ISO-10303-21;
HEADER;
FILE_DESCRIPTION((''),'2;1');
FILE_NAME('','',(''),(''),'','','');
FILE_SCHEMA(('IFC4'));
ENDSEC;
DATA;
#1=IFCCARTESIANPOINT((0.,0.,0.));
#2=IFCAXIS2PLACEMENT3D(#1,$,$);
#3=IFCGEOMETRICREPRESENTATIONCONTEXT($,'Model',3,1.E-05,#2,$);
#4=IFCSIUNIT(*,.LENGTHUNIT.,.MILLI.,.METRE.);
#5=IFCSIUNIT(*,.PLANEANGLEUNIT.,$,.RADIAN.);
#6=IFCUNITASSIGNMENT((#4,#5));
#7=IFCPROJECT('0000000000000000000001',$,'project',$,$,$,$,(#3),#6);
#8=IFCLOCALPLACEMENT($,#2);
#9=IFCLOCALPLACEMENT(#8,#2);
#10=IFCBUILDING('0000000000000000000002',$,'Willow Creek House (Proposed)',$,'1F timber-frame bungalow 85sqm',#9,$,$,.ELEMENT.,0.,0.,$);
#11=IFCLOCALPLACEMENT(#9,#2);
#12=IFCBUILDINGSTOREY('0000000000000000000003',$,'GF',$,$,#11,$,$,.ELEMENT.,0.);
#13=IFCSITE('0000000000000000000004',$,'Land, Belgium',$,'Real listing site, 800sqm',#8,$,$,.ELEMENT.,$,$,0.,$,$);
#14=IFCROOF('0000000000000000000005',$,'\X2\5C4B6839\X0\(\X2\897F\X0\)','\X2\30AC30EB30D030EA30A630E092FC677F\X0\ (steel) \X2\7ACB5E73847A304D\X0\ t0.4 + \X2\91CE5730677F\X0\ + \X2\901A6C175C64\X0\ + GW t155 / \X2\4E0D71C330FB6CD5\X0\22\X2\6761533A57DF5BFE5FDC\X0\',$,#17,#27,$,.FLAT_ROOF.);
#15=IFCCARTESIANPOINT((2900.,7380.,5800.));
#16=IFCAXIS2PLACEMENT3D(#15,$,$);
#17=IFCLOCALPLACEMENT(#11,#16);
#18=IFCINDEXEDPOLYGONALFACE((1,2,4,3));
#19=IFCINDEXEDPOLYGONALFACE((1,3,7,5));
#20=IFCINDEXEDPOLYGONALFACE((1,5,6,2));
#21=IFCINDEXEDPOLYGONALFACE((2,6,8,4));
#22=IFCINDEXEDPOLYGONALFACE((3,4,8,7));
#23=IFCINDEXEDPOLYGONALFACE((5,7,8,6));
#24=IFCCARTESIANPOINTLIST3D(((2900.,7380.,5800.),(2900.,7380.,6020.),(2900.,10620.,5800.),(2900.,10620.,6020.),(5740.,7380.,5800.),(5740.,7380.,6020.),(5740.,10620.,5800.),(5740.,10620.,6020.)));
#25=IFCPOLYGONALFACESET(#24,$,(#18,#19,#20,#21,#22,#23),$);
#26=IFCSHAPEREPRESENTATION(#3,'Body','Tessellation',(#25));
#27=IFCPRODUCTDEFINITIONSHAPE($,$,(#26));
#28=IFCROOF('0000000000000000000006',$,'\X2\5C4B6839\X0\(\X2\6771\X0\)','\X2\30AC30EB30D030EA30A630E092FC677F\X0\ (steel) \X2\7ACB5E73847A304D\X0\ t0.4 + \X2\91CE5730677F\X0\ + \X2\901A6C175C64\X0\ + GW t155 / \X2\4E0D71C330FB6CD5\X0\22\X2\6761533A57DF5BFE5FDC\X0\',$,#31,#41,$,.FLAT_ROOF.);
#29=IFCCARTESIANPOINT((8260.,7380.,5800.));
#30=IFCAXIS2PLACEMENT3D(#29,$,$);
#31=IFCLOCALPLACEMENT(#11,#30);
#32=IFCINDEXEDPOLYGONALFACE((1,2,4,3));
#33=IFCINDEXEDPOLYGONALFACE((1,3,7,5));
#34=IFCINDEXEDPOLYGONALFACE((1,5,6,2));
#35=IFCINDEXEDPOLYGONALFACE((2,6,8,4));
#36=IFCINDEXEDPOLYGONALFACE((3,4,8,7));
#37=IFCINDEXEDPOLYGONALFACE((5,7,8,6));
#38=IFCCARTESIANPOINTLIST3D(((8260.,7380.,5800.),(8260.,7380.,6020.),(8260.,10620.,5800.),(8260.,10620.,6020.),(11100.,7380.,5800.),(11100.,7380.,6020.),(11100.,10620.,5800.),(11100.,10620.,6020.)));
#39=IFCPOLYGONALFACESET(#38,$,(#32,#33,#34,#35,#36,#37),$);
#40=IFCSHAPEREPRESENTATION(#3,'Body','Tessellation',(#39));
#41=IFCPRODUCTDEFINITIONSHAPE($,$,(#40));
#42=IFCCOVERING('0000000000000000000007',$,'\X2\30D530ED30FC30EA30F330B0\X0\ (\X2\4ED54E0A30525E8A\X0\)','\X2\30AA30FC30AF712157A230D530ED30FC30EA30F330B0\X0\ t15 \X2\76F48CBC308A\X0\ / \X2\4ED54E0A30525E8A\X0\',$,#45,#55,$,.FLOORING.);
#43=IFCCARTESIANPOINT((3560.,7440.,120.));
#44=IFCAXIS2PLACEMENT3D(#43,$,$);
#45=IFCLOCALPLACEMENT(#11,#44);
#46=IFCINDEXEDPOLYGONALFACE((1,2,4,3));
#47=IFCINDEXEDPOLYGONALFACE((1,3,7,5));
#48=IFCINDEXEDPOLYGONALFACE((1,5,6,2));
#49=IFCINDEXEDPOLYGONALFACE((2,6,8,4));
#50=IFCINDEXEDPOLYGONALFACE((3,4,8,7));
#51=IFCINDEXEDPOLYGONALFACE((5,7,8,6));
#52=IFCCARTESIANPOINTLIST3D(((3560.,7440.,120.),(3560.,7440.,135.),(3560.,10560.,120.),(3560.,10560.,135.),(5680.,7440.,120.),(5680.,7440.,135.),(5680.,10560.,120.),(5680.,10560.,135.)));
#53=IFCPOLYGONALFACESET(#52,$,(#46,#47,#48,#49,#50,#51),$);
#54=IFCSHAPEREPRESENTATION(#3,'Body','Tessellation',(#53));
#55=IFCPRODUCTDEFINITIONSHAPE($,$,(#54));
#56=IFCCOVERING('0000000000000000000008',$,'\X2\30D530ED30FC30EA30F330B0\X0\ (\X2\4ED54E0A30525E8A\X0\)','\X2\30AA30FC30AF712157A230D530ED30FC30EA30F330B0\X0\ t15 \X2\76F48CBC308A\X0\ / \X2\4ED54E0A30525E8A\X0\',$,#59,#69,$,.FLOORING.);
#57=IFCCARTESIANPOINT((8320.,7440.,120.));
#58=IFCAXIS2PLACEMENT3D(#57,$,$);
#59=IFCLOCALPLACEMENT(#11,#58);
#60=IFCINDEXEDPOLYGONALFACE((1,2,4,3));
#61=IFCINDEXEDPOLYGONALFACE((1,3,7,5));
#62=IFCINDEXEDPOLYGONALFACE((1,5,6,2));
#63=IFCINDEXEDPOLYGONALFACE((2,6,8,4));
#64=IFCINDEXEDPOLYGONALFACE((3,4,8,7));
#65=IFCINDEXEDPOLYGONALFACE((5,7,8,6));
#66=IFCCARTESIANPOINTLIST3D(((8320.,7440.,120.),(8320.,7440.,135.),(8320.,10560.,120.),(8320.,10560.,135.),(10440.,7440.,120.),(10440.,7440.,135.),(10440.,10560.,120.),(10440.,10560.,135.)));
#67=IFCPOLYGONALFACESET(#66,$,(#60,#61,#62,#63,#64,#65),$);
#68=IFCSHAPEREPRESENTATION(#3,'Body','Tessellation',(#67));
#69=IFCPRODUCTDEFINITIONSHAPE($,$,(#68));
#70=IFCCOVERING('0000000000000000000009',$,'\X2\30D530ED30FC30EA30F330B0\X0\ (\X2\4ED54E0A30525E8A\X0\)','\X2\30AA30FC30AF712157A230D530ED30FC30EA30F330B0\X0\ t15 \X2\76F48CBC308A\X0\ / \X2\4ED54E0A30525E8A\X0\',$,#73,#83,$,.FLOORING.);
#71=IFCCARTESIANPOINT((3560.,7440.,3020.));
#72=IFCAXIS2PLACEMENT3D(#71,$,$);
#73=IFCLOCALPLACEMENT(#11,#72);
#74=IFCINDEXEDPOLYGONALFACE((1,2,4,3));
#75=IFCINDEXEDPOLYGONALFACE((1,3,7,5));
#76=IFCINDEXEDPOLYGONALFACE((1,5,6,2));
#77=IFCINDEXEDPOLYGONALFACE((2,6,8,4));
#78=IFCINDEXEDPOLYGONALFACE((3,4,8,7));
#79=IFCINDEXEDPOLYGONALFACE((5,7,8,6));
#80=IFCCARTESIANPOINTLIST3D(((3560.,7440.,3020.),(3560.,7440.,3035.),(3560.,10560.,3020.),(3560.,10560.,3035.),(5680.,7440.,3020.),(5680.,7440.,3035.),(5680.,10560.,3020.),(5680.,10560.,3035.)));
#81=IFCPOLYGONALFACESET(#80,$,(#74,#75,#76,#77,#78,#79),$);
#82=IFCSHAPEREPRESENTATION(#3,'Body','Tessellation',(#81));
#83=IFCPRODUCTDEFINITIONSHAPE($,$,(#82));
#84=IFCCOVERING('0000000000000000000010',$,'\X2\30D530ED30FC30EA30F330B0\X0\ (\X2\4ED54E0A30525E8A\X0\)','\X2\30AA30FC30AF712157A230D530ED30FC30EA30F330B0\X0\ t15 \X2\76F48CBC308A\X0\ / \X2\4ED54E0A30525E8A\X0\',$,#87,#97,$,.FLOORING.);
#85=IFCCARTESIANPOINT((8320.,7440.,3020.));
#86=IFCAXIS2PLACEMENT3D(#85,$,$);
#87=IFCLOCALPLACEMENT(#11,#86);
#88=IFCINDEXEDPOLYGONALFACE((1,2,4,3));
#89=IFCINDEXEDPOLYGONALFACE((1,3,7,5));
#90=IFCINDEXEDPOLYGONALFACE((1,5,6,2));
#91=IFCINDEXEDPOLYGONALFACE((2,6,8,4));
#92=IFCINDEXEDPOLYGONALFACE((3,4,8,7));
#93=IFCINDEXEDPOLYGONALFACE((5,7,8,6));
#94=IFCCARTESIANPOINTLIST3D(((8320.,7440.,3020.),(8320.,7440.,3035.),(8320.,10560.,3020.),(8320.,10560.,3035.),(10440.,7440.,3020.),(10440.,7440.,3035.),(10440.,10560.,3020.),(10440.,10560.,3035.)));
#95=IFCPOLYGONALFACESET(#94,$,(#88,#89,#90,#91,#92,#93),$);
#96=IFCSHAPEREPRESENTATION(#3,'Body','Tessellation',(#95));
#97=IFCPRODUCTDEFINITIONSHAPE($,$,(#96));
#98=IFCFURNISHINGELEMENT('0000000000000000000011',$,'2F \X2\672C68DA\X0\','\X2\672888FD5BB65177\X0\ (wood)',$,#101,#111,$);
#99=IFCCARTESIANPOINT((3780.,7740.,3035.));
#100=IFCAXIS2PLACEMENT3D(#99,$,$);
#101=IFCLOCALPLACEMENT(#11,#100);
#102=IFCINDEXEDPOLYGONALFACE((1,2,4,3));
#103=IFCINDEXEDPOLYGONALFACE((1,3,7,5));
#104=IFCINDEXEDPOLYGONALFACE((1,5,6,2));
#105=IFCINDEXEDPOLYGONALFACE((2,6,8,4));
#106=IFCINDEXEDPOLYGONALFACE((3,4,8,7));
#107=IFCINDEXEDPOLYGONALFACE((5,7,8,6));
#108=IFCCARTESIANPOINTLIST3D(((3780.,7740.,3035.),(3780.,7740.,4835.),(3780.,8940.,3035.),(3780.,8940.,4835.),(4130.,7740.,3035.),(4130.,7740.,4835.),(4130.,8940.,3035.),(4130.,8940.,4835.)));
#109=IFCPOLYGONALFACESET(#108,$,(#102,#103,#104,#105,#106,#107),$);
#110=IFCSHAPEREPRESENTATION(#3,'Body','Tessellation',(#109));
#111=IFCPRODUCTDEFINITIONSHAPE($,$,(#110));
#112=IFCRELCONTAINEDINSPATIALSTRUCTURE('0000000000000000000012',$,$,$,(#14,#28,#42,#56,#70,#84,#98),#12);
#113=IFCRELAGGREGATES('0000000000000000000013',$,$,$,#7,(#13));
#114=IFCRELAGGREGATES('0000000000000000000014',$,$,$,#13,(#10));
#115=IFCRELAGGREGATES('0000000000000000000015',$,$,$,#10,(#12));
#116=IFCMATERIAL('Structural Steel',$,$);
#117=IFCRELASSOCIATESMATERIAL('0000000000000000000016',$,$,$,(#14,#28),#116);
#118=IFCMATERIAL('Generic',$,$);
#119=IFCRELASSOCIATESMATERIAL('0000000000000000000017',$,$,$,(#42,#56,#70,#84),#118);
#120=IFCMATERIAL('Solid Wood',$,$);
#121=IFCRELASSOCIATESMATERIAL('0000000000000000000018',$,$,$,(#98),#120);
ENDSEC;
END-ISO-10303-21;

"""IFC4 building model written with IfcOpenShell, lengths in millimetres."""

from ifc_helpers import new_model, si_unit, frame, frame_2d, origin, place, context, project, spatial, rectangle, extrude, material, element, save


model = new_model("IFC4")

# Units and contexts
model_context = context("Model", 3, precision=1e-05, world=origin())
ifc_project = project(units=[si_unit("LENGTHUNIT", "METRE", prefix="MILLI"), si_unit("PLANEANGLEUNIT", "RADIAN")], contexts=[model_context])

# Site, building, storey
site_placement = place(None, origin())
site = spatial("IfcSite", under=ifc_project, at=site_placement, Name="Land, Belgium", ObjectType="Real listing site, 800sqm", CompositionType="ELEMENT", RefElevation=0.0)
building_placement = place(site_placement, origin())
building = spatial("IfcBuilding", under=site, at=building_placement, Name="Willow Creek House (Proposed)", ObjectType="1F timber-frame bungalow 85sqm", CompositionType="ELEMENT", ElevationOfRefHeight=0.0, ElevationOfTerrain=0.0)
storey_placement = place(building_placement, origin())
storey = spatial("IfcBuildingStorey", under=building, at=storey_placement, Name="GF", CompositionType="ELEMENT", Elevation=0.0)

# Shared definitions
ifc_material_1 = material(Name="Solid Wood")

# Shared definitions
ifc_material_2 = material(Name="Generic")

# Roofs
ifc_material_3 = material(Name="Structural Steel")
roof_1_placement = place(storey_placement, frame((2900.0, 7380.0, 5800.0)))
element("IfcRoof", 1, at=roof_1_placement, inside=storey, material=ifc_material_3, Name="屋根(西)", Description="ガルバリウム鋼板 (steel) 立平葺き t0.4 + 野地板 + 通気層 + GW t155 / 不燃・法22条区域対応", PredefinedType="FLAT_ROOF", context=model_context, shape_type="SweptSolid", body=[
    extrude(rectangle(XDim=2840.0, YDim=3240.0, at=frame_2d((1420.0, 1620.0))), frame((2900.0, 7380.0, 5800.0)), (0.0, 0.0, 1.0), 220.0),
])
roof_2_placement = place(storey_placement, frame((8260.0, 7380.0, 5800.0)))
element("IfcRoof", 2, at=roof_2_placement, inside=storey, material=ifc_material_3, Name="屋根(東)", Description="ガルバリウム鋼板 (steel) 立平葺き t0.4 + 野地板 + 通気層 + GW t155 / 不燃・法22条区域対応", PredefinedType="FLAT_ROOF", context=model_context, shape_type="SweptSolid", body=[
    extrude(rectangle(XDim=2840.0, YDim=3240.0, at=frame_2d((1420.0, 1620.0))), frame((8260.0, 7380.0, 5800.0)), (0.0, 0.0, 1.0), 220.0),
])

# Coverings
covering_1_placement = place(storey_placement, frame((3560.0, 7440.0, 120.0)))
element("IfcCovering", 3, at=covering_1_placement, inside=storey, material=ifc_material_2, Name="フローリング (仕上げ床)", Description="オーク無垢フローリング t15 直貼り / 仕上げ床", PredefinedType="FLOORING", context=model_context, shape_type="SweptSolid", body=[
    extrude(rectangle(XDim=2120.0, YDim=3120.0, at=frame_2d((1060.0, 1560.0))), frame((3560.0, 7440.0, 120.0)), (0.0, 0.0, 1.0), 15.0),
])
covering_2_placement = place(storey_placement, frame((8320.0, 7440.0, 120.0)))
element("IfcCovering", 4, at=covering_2_placement, inside=storey, material=ifc_material_2, Name="フローリング (仕上げ床)", Description="オーク無垢フローリング t15 直貼り / 仕上げ床", PredefinedType="FLOORING", context=model_context, shape_type="SweptSolid", body=[
    extrude(rectangle(XDim=2120.0, YDim=3120.0, at=frame_2d((1060.0, 1560.0))), frame((8320.0, 7440.0, 120.0)), (0.0, 0.0, 1.0), 15.0),
])
covering_3_placement = place(storey_placement, frame((3560.0, 7440.0, 3020.0)))
element("IfcCovering", 5, at=covering_3_placement, inside=storey, material=ifc_material_2, Name="フローリング (仕上げ床)", Description="オーク無垢フローリング t15 直貼り / 仕上げ床", PredefinedType="FLOORING", context=model_context, shape_type="SweptSolid", body=[
    extrude(rectangle(XDim=2120.0, YDim=3120.0, at=frame_2d((1060.0, 1560.0))), frame((3560.0, 7440.0, 3020.0)), (0.0, 0.0, 1.0), 15.0),
])
covering_4_placement = place(storey_placement, frame((8320.0, 7440.0, 3020.0)))
element("IfcCovering", 6, at=covering_4_placement, inside=storey, material=ifc_material_2, Name="フローリング (仕上げ床)", Description="オーク無垢フローリング t15 直貼り / 仕上げ床", PredefinedType="FLOORING", context=model_context, shape_type="SweptSolid", body=[
    extrude(rectangle(XDim=2120.0, YDim=3120.0, at=frame_2d((1060.0, 1560.0))), frame((8320.0, 7440.0, 3020.0)), (0.0, 0.0, 1.0), 15.0),
])

# Furnishing element
furnishing_placement = place(storey_placement, frame((3780.0, 7740.0, 3035.0)))
element("IfcFurnishingElement", 7, at=furnishing_placement, inside=storey, material=ifc_material_1, Name="2F 本棚", Description="木製家具 (wood)", context=model_context, shape_type="SweptSolid", body=[
    extrude(rectangle(XDim=350.0, YDim=1200.0, at=frame_2d((175.0, 600.0))), frame((3780.0, 7740.0, 3035.0)), (0.0, 0.0, 1.0), 1800.0),
])

save(model, "model.ifc")
